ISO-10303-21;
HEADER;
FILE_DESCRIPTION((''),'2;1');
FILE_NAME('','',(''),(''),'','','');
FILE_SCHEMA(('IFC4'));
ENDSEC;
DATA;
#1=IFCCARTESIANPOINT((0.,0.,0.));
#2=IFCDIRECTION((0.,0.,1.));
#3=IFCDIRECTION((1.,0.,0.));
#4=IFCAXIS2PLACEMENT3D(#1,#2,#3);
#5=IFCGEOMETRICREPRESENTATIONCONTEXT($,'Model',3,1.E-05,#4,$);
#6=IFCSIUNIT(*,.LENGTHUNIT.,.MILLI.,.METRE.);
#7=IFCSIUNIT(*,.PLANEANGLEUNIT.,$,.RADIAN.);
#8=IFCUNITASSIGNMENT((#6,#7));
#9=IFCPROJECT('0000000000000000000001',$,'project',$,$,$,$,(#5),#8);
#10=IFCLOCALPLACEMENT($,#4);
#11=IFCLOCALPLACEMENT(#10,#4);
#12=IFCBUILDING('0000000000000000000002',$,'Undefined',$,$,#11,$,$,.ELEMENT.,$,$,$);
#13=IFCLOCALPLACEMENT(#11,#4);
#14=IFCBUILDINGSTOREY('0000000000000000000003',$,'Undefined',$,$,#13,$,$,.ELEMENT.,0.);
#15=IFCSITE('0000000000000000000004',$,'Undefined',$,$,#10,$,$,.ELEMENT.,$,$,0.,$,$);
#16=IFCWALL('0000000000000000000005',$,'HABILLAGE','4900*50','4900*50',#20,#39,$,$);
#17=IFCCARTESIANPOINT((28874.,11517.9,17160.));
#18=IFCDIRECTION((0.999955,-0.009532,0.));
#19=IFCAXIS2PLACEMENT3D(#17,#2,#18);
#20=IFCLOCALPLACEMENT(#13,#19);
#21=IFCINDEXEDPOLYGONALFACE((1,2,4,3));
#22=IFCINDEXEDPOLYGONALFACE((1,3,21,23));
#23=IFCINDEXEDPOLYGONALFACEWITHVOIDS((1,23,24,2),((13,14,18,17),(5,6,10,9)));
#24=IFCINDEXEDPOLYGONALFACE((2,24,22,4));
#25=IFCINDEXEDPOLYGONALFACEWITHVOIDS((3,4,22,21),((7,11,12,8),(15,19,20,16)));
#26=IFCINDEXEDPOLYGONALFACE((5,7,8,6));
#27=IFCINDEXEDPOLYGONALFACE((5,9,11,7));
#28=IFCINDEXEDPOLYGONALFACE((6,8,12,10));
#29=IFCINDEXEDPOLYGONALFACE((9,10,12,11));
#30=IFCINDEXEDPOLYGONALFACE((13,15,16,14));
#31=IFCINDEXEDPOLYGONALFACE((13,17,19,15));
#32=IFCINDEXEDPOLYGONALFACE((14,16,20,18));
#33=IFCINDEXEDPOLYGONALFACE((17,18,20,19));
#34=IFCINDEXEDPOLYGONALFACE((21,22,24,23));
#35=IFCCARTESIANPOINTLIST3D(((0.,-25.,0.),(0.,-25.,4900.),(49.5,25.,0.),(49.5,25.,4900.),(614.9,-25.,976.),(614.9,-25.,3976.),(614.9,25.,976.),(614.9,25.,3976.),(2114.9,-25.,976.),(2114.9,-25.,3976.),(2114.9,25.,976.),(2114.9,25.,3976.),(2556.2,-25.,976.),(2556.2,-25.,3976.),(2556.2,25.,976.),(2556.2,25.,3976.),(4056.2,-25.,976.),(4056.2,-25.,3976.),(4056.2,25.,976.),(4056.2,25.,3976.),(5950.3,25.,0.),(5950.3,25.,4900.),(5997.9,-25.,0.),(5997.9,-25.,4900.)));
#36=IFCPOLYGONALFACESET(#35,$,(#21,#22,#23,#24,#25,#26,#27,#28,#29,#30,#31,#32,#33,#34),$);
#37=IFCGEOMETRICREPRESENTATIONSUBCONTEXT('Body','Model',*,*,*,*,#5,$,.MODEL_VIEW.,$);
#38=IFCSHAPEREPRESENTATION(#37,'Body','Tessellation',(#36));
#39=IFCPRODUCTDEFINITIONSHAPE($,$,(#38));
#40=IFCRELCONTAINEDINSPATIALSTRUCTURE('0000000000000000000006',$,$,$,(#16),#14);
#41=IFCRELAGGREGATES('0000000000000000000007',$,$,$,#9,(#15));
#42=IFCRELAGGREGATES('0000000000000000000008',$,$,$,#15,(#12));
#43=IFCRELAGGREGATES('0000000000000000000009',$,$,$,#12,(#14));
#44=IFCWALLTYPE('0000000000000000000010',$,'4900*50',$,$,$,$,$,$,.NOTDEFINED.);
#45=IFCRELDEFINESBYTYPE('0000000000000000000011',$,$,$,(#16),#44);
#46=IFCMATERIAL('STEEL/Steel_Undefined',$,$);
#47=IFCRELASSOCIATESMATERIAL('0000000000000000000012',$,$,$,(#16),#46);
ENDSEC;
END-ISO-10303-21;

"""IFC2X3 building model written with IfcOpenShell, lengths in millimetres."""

from ifc_helpers import new_model, si_unit, frame, frame_2d, origin_with_axes, origin_2d_with_axis, place, context, subcontext, project, spatial, rectangle, extrude, boolean, halfspace, material, type_object, element, save


model = new_model("IFC2X3")

# Units and contexts
model_context = context("Model", 3, precision=1e-05, world=origin_with_axes())
body_context = subcontext(model_context, "Body", "Model", "MODEL_VIEW")
ifc_project = project(units=[si_unit("LENGTHUNIT", "METRE", prefix="MILLI"), si_unit("PLANEANGLEUNIT", "RADIAN")], contexts=[model_context])

# Site, building, storey
site_placement = place(None, origin_with_axes())
site = spatial("IfcSite", under=ifc_project, at=site_placement, Name="Undefined", CompositionType="ELEMENT", RefElevation=0.0)
building_placement = place(site_placement, origin_with_axes())
building = spatial("IfcBuilding", under=site, at=building_placement, Name="Undefined", CompositionType="ELEMENT")
storey_placement = place(building_placement, origin_with_axes())
storey = spatial("IfcBuildingStorey", under=building, at=storey_placement, Name="Undefined", CompositionType="ELEMENT", Elevation=0.0)

# Wall
ifc_material_1 = material(Name="STEEL/Steel_Undefined")
wall_type_1 = type_object("IfcWallType", Name="4900*50", PredefinedType="NOTDEFINED")
wall_1_placement = place(storey_placement, frame((28874.0, 11517.9, 17160.0), z_axis=(0.0, 0.0, 1.0), x_axis=(0.999955, -0.009532, 0.0)))
element("IfcWall", 1, at=wall_1_placement, inside=storey, type_object=wall_type_1, material=ifc_material_1, Name="HABILLAGE", Description="4900*50", ObjectType="4900*50", context=body_context, shape_type="CSG", body=[
    boolean("DIFFERENCE", boolean("DIFFERENCE", boolean("DIFFERENCE", boolean("DIFFERENCE", extrude(rectangle(XDim=6165.1, YDim=50.0, at=frame_2d((0.0, 2999.4), x_axis=(0.0, -1.0))), frame((0.0, 0.0, 0.0), z_axis=(0.0, 0.0, 1.0), x_axis=(0.0, -1.0, 0.0)), (0.0, 0.0, 1.0), 4900.0), extrude(rectangle(XDim=1500.0, YDim=3000.0, at=origin_2d_with_axis()), frame((3306.2, -35.0, 2476.0), z_axis=(0.0, 1.0, 0.0), x_axis=(-1.0, 0.0, 0.0)), (0.0, 0.0, 1.0), 70.0)), extrude(rectangle(XDim=1500.0, YDim=3000.0, at=origin_2d_with_axis()), frame((1364.9, -35.0, 2476.0), z_axis=(0.0, 1.0, 0.0), x_axis=(-1.0, 0.0, 0.0)), (0.0, 0.0, 1.0), 70.0)), halfspace(frame((5997.9, -25.0, 2450.0), z_axis=(0.724446, 0.689332, 0.0), x_axis=(0.0, 0.0, 1.0)), False)), halfspace(frame((0.0, -25.0, 2450.0), z_axis=(0.710468, -0.70373, 0.0), x_axis=(0.0, 0.0, 1.0)), True)),
])

save(model, "model.ifc")
